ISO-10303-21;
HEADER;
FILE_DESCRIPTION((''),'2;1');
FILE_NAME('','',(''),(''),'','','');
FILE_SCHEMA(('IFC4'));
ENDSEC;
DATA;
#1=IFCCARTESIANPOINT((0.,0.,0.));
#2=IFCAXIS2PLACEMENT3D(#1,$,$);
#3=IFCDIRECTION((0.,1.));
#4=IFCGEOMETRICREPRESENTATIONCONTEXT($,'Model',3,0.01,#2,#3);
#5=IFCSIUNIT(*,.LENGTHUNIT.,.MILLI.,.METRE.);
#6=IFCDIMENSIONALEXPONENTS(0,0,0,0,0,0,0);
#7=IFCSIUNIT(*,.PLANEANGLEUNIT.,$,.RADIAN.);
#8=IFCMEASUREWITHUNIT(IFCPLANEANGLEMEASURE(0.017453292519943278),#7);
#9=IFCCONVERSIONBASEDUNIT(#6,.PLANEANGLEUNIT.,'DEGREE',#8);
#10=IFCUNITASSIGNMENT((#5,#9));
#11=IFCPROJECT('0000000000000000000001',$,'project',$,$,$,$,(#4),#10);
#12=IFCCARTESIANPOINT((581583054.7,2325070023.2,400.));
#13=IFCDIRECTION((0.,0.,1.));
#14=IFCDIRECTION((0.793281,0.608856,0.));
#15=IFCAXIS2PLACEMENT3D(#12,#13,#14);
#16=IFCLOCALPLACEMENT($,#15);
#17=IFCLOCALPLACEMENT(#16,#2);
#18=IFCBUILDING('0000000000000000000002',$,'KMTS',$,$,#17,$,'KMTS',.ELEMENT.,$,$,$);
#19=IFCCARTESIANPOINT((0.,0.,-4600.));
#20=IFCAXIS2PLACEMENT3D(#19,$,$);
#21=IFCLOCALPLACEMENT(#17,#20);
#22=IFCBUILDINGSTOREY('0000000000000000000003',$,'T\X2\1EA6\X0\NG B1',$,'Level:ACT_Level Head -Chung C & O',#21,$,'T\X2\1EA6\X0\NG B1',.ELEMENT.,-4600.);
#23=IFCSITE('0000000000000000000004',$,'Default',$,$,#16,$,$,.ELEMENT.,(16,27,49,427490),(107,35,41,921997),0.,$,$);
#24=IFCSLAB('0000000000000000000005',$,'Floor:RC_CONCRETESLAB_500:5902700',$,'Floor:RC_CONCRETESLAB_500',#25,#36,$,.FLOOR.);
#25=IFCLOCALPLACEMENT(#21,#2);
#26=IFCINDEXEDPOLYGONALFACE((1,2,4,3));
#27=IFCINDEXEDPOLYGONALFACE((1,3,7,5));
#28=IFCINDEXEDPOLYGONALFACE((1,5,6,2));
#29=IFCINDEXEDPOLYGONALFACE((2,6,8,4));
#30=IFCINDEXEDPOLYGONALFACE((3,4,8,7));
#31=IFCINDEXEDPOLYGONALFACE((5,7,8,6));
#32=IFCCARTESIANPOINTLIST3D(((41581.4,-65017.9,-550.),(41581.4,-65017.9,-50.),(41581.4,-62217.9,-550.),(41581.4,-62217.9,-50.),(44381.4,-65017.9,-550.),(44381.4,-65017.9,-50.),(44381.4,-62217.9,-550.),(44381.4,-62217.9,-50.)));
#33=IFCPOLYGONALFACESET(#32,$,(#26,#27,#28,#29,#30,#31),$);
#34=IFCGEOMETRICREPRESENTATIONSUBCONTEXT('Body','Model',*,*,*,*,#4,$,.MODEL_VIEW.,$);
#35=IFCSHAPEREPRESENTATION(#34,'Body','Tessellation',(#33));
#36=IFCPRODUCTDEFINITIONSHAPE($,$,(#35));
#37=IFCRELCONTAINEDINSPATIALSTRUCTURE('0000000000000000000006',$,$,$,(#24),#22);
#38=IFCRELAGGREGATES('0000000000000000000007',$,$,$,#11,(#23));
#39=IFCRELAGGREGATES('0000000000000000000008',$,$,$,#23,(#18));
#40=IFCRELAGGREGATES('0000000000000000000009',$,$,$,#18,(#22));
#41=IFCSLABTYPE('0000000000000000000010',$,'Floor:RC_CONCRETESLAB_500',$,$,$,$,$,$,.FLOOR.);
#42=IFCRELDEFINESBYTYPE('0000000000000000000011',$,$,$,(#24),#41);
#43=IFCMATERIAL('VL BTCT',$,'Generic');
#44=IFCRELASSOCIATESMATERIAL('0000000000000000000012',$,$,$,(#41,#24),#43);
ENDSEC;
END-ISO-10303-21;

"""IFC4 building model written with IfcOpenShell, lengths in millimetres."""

from ifc_helpers import new_model, entity, si_unit, converted_unit, direction, frame, origin, place, context, subcontext, project, spatial, indexed_curve, outline, extrude, material, type_object, element, save


model = new_model("IFC4")

# Units and contexts
model_context = context("Model", 3, precision=0.01, world=origin(), true_north=direction((0.0, 1.0)))
body_context = subcontext(model_context, "Body", "Model", "MODEL_VIEW")
ifc_project = project(units=[si_unit("LENGTHUNIT", "METRE", prefix="MILLI"), converted_unit("PLANEANGLEUNIT", "DEGREE", entity("IfcPlaneAngleMeasure", 0.017453292519943278), si_unit("PLANEANGLEUNIT", "RADIAN"), dimensions=[0, 0, 0, 0, 0, 0, 0])], contexts=[model_context])

# Site, building, storey
site_placement = place(None, frame((581583054.7, 2325070023.2, 400.0), z_axis=(0.0, 0.0, 1.0), x_axis=(0.793281, 0.608856, 0.0)))
site = spatial("IfcSite", under=ifc_project, at=site_placement, Name="Default", CompositionType="ELEMENT", RefLatitude=(16, 27, 49, 427490), RefLongitude=(107, 35, 41, 921997), RefElevation=0.0)
building_placement = place(site_placement, origin())
building = spatial("IfcBuilding", under=site, at=building_placement, Name="KMTS", LongName="KMTS", CompositionType="ELEMENT")
storey_placement = place(building_placement, frame((0.0, 0.0, -4600.0)))
storey = spatial("IfcBuildingStorey", under=building, at=storey_placement, Name="TẦNG B1", ObjectType="Level:ACT_Level Head -Chung C & O", LongName="TẦNG B1", CompositionType="ELEMENT", Elevation=-4600.0)

# Slab
ifc_material = material(Name="VL BTCT", Category="Generic")
slab_type = type_object("IfcSlabType", Name="Floor:RC_CONCRETESLAB_500", PredefinedType="FLOOR", material=ifc_material)
slab_1_placement = place(storey_placement, origin())
element("IfcSlab", 1, at=slab_1_placement, inside=storey, type_object=slab_type, material=ifc_material, Name="Floor:RC_CONCRETESLAB_500:5902700", ObjectType="Floor:RC_CONCRETESLAB_500", PredefinedType="FLOOR", context=body_context, shape_type="SweptSolid", body=[
    extrude(outline(indexed_curve([(-1400.0, -1400.0), (1400.0, -1400.0), (1400.0, 1400.0), (-1400.0, 1400.0), (-1400.0, -1400.0)], self_intersect=False)), frame((42981.4, -63617.9, -50.0), z_axis=(0.0, 0.0, -1.0), x_axis=(0.0, 1.0, 0.0)), (0.0, 0.0, 1.0), 500.0),
])

save(model, "model.ifc")
